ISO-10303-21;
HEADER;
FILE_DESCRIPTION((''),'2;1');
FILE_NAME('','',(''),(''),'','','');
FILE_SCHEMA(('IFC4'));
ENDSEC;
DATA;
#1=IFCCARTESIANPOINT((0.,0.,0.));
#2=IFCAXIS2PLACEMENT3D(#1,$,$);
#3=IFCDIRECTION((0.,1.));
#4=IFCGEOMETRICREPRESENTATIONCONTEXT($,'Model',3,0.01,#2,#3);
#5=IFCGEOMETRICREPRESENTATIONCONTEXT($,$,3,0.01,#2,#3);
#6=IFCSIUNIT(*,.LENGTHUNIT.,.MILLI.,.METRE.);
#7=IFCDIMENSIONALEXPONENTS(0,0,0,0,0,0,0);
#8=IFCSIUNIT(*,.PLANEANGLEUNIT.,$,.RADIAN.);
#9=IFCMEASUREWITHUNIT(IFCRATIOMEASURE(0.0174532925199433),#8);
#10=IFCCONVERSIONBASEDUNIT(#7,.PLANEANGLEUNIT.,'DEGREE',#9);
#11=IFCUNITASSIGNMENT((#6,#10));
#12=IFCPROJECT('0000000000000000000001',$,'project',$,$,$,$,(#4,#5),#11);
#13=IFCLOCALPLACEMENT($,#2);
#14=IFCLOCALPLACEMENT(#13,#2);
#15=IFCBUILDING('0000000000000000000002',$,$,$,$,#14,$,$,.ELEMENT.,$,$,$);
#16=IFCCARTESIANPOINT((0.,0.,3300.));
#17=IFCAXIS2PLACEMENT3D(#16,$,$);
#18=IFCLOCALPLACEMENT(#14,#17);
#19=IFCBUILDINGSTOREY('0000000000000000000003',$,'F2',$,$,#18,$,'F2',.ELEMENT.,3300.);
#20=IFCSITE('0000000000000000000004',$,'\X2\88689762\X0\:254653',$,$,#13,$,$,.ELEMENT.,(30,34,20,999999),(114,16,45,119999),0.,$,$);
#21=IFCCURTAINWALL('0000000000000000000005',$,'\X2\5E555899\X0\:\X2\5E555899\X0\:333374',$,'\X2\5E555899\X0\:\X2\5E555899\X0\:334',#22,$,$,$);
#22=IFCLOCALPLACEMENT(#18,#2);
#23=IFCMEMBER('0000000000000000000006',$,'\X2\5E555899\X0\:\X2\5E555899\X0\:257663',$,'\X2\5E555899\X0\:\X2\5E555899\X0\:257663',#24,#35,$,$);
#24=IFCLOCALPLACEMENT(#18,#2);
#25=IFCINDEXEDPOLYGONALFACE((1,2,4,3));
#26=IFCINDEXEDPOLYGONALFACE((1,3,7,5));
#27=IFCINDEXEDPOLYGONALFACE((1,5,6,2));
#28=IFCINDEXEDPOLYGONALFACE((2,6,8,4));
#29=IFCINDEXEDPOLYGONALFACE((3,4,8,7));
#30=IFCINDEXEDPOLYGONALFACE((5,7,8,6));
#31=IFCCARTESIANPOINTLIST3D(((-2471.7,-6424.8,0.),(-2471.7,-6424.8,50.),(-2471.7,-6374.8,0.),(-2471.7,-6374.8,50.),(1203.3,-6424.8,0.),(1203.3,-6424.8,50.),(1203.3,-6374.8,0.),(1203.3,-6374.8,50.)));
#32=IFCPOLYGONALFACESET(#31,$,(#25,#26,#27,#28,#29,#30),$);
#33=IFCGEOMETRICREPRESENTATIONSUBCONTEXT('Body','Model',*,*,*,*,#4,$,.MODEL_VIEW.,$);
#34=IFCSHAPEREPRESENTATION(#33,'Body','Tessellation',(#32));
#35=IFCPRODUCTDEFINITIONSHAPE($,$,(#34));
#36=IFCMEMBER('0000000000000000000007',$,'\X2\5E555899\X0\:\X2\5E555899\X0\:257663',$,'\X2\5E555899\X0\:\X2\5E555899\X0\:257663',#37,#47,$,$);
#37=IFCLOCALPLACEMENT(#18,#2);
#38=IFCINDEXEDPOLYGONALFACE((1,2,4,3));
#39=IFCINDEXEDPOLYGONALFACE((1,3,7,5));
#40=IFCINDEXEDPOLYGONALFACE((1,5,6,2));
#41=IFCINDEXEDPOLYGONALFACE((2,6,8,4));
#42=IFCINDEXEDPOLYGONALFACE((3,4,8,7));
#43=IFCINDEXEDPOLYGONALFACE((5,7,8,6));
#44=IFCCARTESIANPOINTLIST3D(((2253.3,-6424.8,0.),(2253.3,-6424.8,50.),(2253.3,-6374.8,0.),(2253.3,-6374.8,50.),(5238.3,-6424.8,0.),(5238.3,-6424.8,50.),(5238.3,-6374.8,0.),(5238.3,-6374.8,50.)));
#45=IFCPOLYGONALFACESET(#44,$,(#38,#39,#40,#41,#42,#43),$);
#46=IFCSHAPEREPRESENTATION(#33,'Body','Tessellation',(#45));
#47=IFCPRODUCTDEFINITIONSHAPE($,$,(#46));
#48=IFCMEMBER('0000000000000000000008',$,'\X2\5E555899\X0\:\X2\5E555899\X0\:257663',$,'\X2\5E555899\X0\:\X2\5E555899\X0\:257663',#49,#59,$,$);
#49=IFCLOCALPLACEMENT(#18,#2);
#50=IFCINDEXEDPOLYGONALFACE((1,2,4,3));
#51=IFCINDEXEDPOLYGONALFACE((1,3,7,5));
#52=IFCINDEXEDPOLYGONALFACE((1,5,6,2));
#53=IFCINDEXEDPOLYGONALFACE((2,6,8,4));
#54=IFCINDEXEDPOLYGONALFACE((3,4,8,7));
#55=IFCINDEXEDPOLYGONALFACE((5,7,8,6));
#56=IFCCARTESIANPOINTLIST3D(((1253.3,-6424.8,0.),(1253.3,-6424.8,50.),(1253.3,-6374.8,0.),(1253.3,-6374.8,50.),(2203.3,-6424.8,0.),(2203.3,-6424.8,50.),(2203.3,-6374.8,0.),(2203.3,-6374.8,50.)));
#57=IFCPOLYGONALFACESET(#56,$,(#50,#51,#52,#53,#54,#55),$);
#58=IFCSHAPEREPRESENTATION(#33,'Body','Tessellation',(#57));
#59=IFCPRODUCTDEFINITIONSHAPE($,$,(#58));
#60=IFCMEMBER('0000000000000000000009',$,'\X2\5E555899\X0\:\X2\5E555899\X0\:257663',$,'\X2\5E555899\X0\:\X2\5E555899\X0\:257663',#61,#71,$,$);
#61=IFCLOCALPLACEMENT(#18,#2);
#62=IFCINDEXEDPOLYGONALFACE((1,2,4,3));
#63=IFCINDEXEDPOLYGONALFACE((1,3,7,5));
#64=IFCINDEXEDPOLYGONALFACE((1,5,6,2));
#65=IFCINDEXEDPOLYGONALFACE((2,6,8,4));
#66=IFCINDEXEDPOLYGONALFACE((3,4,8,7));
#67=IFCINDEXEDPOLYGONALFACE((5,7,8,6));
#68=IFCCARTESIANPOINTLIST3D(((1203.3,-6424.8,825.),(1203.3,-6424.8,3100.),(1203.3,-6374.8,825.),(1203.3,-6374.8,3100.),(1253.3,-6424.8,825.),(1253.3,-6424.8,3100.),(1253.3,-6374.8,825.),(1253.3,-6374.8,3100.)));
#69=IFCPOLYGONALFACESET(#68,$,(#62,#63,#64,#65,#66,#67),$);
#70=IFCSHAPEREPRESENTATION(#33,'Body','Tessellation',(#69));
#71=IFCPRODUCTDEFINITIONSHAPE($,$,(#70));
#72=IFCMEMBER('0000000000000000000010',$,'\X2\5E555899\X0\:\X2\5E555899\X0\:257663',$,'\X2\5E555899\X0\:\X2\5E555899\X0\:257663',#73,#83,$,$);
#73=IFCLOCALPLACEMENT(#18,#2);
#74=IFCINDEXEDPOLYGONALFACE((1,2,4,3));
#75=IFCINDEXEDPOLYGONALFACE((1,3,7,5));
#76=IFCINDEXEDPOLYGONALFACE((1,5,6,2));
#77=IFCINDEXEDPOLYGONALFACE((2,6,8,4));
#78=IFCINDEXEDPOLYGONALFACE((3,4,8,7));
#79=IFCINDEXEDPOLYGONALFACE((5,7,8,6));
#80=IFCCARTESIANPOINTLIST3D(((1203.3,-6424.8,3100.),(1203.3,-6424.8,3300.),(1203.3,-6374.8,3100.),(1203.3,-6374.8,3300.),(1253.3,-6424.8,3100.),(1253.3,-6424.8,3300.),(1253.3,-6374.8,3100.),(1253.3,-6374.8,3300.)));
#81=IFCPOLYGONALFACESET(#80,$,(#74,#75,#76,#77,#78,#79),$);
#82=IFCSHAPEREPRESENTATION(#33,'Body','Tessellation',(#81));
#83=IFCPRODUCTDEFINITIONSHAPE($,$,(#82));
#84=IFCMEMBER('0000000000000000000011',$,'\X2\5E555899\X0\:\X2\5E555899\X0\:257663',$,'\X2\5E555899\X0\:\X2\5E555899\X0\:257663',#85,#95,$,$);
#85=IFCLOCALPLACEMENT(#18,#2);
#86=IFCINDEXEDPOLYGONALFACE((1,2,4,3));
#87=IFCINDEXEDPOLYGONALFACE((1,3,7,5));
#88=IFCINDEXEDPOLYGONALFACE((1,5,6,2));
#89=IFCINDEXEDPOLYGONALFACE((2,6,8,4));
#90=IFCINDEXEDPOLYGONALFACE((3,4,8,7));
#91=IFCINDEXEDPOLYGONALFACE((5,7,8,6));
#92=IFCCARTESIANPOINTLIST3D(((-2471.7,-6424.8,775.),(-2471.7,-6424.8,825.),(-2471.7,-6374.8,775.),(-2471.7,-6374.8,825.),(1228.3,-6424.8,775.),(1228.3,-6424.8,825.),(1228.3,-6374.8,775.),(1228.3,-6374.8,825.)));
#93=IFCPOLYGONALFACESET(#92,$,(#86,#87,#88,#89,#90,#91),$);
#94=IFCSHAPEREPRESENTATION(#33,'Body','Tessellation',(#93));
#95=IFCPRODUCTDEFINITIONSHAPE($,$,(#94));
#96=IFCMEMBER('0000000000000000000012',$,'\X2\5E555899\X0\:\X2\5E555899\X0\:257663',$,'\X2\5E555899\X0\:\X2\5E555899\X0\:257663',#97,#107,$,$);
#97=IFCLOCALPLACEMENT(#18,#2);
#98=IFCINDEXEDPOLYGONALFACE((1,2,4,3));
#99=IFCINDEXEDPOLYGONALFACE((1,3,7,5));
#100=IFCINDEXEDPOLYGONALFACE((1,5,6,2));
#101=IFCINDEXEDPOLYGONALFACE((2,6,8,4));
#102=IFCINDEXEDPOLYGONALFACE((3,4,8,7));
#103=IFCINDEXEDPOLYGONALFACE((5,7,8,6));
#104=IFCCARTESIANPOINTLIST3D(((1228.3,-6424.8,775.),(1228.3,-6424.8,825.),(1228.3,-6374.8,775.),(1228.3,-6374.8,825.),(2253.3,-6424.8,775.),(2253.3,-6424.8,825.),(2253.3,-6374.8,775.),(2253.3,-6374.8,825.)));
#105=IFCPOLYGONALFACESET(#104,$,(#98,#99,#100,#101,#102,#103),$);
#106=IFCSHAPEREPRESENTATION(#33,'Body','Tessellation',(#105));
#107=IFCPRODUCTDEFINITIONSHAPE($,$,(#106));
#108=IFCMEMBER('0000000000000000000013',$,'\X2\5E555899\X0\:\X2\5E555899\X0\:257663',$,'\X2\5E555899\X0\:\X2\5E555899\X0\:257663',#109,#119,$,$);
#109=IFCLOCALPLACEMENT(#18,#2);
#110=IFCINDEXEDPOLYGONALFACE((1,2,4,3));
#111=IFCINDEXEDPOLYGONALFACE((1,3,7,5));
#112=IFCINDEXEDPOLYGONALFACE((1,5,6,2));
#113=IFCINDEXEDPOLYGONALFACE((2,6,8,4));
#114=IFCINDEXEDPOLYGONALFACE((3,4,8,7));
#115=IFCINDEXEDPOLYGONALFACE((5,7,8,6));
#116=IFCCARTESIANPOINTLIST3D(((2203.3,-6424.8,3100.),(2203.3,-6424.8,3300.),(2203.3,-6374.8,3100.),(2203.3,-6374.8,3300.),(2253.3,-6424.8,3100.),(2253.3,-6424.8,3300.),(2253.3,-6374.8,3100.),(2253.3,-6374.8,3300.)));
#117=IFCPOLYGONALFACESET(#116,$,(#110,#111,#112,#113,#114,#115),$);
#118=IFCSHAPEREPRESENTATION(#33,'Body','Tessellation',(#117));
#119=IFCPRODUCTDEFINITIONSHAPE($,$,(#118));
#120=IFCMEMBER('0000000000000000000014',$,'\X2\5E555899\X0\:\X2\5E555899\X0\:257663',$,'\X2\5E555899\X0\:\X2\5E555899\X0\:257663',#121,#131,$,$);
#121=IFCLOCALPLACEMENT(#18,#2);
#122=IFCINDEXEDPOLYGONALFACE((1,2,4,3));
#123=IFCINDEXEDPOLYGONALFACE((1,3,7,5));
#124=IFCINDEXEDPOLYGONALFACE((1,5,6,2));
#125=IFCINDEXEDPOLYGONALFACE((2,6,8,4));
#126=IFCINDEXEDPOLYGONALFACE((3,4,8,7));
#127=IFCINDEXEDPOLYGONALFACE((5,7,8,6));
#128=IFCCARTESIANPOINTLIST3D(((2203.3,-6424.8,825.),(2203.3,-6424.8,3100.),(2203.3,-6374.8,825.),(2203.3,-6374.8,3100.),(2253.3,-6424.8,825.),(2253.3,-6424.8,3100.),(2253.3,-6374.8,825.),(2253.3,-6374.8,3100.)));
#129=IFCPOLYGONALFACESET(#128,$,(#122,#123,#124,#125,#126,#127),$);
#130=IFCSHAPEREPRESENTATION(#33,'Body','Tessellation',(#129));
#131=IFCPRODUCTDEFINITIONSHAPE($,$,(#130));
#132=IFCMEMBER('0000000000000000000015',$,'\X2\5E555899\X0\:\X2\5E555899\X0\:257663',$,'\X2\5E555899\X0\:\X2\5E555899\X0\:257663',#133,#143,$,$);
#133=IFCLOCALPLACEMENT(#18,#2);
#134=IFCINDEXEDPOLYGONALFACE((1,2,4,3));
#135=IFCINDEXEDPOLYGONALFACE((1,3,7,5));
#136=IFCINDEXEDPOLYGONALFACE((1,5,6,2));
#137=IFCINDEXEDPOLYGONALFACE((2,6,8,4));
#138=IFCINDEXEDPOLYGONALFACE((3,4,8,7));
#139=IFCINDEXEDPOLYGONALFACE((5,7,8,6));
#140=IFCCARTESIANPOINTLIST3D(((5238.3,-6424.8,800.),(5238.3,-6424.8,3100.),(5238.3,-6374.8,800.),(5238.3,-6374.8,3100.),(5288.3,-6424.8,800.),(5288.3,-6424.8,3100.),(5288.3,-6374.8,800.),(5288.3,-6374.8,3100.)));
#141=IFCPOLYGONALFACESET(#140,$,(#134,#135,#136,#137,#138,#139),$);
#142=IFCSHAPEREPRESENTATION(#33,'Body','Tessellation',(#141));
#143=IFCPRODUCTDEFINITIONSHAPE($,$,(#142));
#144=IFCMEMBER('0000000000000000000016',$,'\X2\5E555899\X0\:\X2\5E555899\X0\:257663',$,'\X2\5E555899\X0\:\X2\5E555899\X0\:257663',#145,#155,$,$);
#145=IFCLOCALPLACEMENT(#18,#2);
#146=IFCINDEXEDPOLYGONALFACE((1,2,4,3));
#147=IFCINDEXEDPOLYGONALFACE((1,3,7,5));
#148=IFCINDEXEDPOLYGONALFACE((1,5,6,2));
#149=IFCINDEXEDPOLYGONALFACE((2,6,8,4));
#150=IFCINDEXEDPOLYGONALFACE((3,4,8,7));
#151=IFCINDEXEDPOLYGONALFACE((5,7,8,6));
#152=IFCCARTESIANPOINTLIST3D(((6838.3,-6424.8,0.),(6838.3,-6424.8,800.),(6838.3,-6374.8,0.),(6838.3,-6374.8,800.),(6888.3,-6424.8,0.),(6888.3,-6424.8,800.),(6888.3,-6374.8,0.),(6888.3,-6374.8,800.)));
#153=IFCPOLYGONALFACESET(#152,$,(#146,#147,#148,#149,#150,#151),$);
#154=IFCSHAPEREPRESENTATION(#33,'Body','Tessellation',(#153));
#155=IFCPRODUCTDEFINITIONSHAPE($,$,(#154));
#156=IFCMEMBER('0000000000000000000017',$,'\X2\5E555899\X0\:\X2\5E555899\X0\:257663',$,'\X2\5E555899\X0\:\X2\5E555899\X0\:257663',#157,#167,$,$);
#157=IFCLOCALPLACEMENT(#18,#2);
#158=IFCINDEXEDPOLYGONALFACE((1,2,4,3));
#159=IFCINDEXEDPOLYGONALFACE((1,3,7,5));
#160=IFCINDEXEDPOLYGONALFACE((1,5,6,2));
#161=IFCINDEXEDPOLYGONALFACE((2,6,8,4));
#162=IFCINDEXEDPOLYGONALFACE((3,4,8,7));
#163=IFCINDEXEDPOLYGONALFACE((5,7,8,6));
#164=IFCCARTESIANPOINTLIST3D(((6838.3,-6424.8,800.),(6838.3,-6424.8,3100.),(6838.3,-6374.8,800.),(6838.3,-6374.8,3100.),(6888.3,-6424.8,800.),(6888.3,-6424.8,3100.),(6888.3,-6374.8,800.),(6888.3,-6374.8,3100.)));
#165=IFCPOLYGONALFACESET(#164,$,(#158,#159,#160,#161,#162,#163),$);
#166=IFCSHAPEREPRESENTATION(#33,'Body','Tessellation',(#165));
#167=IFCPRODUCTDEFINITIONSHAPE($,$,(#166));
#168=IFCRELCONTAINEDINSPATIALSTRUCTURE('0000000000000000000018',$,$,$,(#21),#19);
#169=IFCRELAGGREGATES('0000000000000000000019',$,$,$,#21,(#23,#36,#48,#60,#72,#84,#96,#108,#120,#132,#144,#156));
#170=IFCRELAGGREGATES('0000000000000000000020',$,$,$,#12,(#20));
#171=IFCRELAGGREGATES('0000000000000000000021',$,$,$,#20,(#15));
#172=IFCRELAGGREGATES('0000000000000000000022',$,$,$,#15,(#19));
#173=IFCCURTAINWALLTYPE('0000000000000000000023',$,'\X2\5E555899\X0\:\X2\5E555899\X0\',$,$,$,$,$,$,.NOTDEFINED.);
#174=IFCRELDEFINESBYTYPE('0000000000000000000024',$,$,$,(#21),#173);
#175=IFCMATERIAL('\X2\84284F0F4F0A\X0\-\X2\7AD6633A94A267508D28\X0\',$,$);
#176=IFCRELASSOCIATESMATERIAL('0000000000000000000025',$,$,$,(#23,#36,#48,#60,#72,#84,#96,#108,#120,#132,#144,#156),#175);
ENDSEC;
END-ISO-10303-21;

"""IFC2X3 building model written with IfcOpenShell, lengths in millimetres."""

from ifc_helpers import new_model, entity, si_unit, converted_unit, direction, frame, frame_2d, origin, origin_2d_with_axis, place, context, subcontext, project, spatial, rectangle, extrude, material, type_object, element, aggregate, save


model = new_model("IFC2X3")

# Units and contexts
model_context = context("Model", 3, precision=0.01, world=origin(), true_north=direction((0.0, 1.0)))
context_of_model = context(None, 3, precision=0.01, world=origin(), true_north=direction((0.0, 1.0)))
body_context = subcontext(model_context, "Body", "Model", "MODEL_VIEW")
ifc_project = project(units=[si_unit("LENGTHUNIT", "METRE", prefix="MILLI"), converted_unit("PLANEANGLEUNIT", "DEGREE", entity("IfcRatioMeasure", 0.0174532925199433), si_unit("PLANEANGLEUNIT", "RADIAN"), dimensions=[0, 0, 0, 0, 0, 0, 0])], contexts=[model_context, context_of_model])

# Site, building, storey
site_placement = place(None, origin())
site = spatial("IfcSite", under=ifc_project, at=site_placement, Name="表面:254653", CompositionType="ELEMENT", RefLatitude=(30, 34, 20, 999999), RefLongitude=(114, 16, 45, 119999), RefElevation=0.0)
building_placement = place(site_placement, origin())
building = spatial("IfcBuilding", under=site, at=building_placement, CompositionType="ELEMENT")
storey_placement = place(building_placement, frame((0.0, 0.0, 3300.0)))
storey = spatial("IfcBuildingStorey", under=building, at=storey_placement, Name="F2", LongName="F2", CompositionType="ELEMENT", Elevation=3300.0)

# Curtain wall, members
curtain_wall_type_1 = type_object("IfcCurtainWallType", Name="幕墙:幕墙", PredefinedType="NOTDEFINED")
curtain_wall_placement = place(storey_placement, frame((0.0, 0.0, -3300.0)))
curtain_wall = element("IfcCurtainWall", 1, at=curtain_wall_placement, inside=storey, type_object=curtain_wall_type_1, Name="幕墙:幕墙:333374", ObjectType="幕墙:幕墙:334")
ifc_material_1 = material(Name="萨伏伊-竖挺钢材质")
member_1_placement = place(curtain_wall_placement, frame((0.0, 0.0, 3300.0)))
member_1 = element("IfcMember", 2, at=member_1_placement, material=ifc_material_1, Name="幕墙:幕墙:257663", ObjectType="幕墙:幕墙:257663", context=body_context, shape_type="SweptSolid", body=[
    extrude(rectangle(XDim=50.0, YDim=50.0, at=frame_2d((0.0, 0.0), x_axis=(1.0, 0.0))), frame((-2471.7, -6399.8, 25.0), z_axis=(1.0, 0.0, 0.0), x_axis=(0.0, 0.0, -1.0)), (0.0, 0.0, 1.0), 3675.0),
])
member_2_placement = place(curtain_wall_placement, frame((0.0, 0.0, 3300.0)))
member_2 = element("IfcMember", 3, at=member_2_placement, material=ifc_material_1, Name="幕墙:幕墙:257663", ObjectType="幕墙:幕墙:257663", context=body_context, shape_type="SweptSolid", body=[
    extrude(rectangle(XDim=50.0, YDim=50.0, at=frame_2d((0.0, 0.0), x_axis=(1.0, 0.0))), frame((2253.3, -6399.8, 25.0), z_axis=(1.0, 0.0, 0.0), x_axis=(0.0, 0.0, -1.0)), (0.0, 0.0, 1.0), 2985.0),
])
member_3_placement = place(curtain_wall_placement, frame((0.0, 0.0, 3300.0)))
member_3 = element("IfcMember", 4, at=member_3_placement, material=ifc_material_1, Name="幕墙:幕墙:257663", ObjectType="幕墙:幕墙:257663", context=body_context, shape_type="SweptSolid", body=[
    extrude(rectangle(XDim=50.0, YDim=50.0, at=frame_2d((0.0, 0.0), x_axis=(1.0, 0.0))), frame((1253.3, -6399.8, 25.0), z_axis=(1.0, 0.0, 0.0), x_axis=(0.0, 0.0, -1.0)), (0.0, 0.0, 1.0), 950.0),
])
member_4_placement = place(curtain_wall_placement, frame((0.0, 0.0, 3300.0)))
member_4 = element("IfcMember", 5, at=member_4_placement, material=ifc_material_1, Name="幕墙:幕墙:257663", ObjectType="幕墙:幕墙:257663", context=body_context, shape_type="SweptSolid", body=[
    extrude(rectangle(XDim=50.0, YDim=50.0, at=frame_2d((0.0, 0.0), x_axis=(1.0, 0.0))), frame((1228.3, -6399.8, 825.0), z_axis=(0.0, 0.0, 1.0), x_axis=(-1.0, 0.0, 0.0)), (0.0, 0.0, 1.0), 2275.0),
])
member_5_placement = place(curtain_wall_placement, frame((0.0, 0.0, 3300.0)))
member_5 = element("IfcMember", 6, at=member_5_placement, material=ifc_material_1, Name="幕墙:幕墙:257663", ObjectType="幕墙:幕墙:257663", context=body_context, shape_type="SweptSolid", body=[
    extrude(rectangle(XDim=50.0, YDim=50.0, at=frame_2d((0.0, 0.0), x_axis=(1.0, 0.0))), frame((1228.3, -6399.8, 3100.0), z_axis=(0.0, 0.0, 1.0), x_axis=(-1.0, 0.0, 0.0)), (0.0, 0.0, 1.0), 200.0),
])
member_6_placement = place(curtain_wall_placement, frame((0.0, 0.0, 3300.0)))
member_6 = element("IfcMember", 7, at=member_6_placement, material=ifc_material_1, Name="幕墙:幕墙:257663", ObjectType="幕墙:幕墙:257663", context=body_context, shape_type="SweptSolid", body=[
    extrude(rectangle(XDim=50.0, YDim=50.0, at=frame_2d((0.0, 0.0), x_axis=(1.0, 0.0))), frame((1228.3, -6399.8, 800.0), z_axis=(-1.0, 0.0, 0.0), x_axis=(0.0, 0.0, -1.0)), (0.0, 0.0, 1.0), 3700.0),
])
member_7_placement = place(curtain_wall_placement, frame((0.0, 0.0, 3300.0)))
member_7 = element("IfcMember", 8, at=member_7_placement, material=ifc_material_1, Name="幕墙:幕墙:257663", ObjectType="幕墙:幕墙:257663", context=body_context, shape_type="SweptSolid", body=[
    extrude(rectangle(XDim=50.0, YDim=50.0, at=frame_2d((0.0, 0.0), x_axis=(1.0, 0.0))), frame((2253.3, -6399.8, 800.0), z_axis=(-1.0, 0.0, 0.0), x_axis=(0.0, 0.0, -1.0)), (0.0, 0.0, 1.0), 1025.0),
])
member_8_placement = place(curtain_wall_placement, frame((0.0, 0.0, 3300.0)))
member_8 = element("IfcMember", 9, at=member_8_placement, material=ifc_material_1, Name="幕墙:幕墙:257663", ObjectType="幕墙:幕墙:257663", context=body_context, shape_type="SweptSolid", body=[
    extrude(rectangle(XDim=50.0, YDim=50.0, at=origin_2d_with_axis()), frame((2228.3, -6399.8, 3100.0), z_axis=(0.0, 0.0, 1.0), x_axis=(-1.0, 0.0, 0.0)), (0.0, 0.0, 1.0), 200.0),
])
member_9_placement = place(curtain_wall_placement, frame((0.0, 0.0, 3300.0)))
member_9 = element("IfcMember", 10, at=member_9_placement, material=ifc_material_1, Name="幕墙:幕墙:257663", ObjectType="幕墙:幕墙:257663", context=body_context, shape_type="SweptSolid", body=[
    extrude(rectangle(XDim=50.0, YDim=50.0, at=frame_2d((0.0, 0.0), x_axis=(1.0, 0.0))), frame((2228.3, -6399.8, 825.0), z_axis=(0.0, 0.0, 1.0), x_axis=(-1.0, 0.0, 0.0)), (0.0, 0.0, 1.0), 2275.0),
])
member_10_placement = place(curtain_wall_placement, frame((0.0, 0.0, 3300.0)))
member_10 = element("IfcMember", 11, at=member_10_placement, material=ifc_material_1, Name="幕墙:幕墙:257663", ObjectType="幕墙:幕墙:257663", context=body_context, shape_type="SweptSolid", body=[
    extrude(rectangle(XDim=50.0, YDim=50.0, at=origin_2d_with_axis()), frame((5263.3, -6399.8, 800.0), z_axis=(0.0, 0.0, 1.0), x_axis=(-1.0, 0.0, 0.0)), (0.0, 0.0, 1.0), 2300.0),
])
member_11_placement = place(curtain_wall_placement, frame((0.0, 0.0, 3300.0)))
member_11 = element("IfcMember", 12, at=member_11_placement, material=ifc_material_1, Name="幕墙:幕墙:257663", ObjectType="幕墙:幕墙:257663", context=body_context, shape_type="SweptSolid", body=[
    extrude(rectangle(XDim=50.0, YDim=50.0, at=frame_2d((0.0, 0.0), x_axis=(1.0, 0.0))), frame((6863.3, -6399.8, 800.0), z_axis=(0.0, 0.0, -1.0), x_axis=(-1.0, 0.0, 0.0)), (0.0, 0.0, 1.0), 800.0),
])
member_12_placement = place(curtain_wall_placement, frame((0.0, 0.0, 3300.0)))
member_12 = element("IfcMember", 13, at=member_12_placement, material=ifc_material_1, Name="幕墙:幕墙:257663", ObjectType="幕墙:幕墙:257663", context=body_context, shape_type="SweptSolid", body=[
    extrude(rectangle(XDim=50.0, YDim=50.0, at=frame_2d((0.0, 0.0), x_axis=(1.0, 0.0))), frame((6863.3, -6399.8, 3100.0), z_axis=(0.0, 0.0, -1.0), x_axis=(-1.0, 0.0, 0.0)), (0.0, 0.0, 1.0), 2300.0),
])
aggregate(curtain_wall, [member_1, member_2, member_3, member_4, member_5, member_6, member_7, member_8, member_9, member_10, member_11, member_12])

save(model, "model.ifc")
